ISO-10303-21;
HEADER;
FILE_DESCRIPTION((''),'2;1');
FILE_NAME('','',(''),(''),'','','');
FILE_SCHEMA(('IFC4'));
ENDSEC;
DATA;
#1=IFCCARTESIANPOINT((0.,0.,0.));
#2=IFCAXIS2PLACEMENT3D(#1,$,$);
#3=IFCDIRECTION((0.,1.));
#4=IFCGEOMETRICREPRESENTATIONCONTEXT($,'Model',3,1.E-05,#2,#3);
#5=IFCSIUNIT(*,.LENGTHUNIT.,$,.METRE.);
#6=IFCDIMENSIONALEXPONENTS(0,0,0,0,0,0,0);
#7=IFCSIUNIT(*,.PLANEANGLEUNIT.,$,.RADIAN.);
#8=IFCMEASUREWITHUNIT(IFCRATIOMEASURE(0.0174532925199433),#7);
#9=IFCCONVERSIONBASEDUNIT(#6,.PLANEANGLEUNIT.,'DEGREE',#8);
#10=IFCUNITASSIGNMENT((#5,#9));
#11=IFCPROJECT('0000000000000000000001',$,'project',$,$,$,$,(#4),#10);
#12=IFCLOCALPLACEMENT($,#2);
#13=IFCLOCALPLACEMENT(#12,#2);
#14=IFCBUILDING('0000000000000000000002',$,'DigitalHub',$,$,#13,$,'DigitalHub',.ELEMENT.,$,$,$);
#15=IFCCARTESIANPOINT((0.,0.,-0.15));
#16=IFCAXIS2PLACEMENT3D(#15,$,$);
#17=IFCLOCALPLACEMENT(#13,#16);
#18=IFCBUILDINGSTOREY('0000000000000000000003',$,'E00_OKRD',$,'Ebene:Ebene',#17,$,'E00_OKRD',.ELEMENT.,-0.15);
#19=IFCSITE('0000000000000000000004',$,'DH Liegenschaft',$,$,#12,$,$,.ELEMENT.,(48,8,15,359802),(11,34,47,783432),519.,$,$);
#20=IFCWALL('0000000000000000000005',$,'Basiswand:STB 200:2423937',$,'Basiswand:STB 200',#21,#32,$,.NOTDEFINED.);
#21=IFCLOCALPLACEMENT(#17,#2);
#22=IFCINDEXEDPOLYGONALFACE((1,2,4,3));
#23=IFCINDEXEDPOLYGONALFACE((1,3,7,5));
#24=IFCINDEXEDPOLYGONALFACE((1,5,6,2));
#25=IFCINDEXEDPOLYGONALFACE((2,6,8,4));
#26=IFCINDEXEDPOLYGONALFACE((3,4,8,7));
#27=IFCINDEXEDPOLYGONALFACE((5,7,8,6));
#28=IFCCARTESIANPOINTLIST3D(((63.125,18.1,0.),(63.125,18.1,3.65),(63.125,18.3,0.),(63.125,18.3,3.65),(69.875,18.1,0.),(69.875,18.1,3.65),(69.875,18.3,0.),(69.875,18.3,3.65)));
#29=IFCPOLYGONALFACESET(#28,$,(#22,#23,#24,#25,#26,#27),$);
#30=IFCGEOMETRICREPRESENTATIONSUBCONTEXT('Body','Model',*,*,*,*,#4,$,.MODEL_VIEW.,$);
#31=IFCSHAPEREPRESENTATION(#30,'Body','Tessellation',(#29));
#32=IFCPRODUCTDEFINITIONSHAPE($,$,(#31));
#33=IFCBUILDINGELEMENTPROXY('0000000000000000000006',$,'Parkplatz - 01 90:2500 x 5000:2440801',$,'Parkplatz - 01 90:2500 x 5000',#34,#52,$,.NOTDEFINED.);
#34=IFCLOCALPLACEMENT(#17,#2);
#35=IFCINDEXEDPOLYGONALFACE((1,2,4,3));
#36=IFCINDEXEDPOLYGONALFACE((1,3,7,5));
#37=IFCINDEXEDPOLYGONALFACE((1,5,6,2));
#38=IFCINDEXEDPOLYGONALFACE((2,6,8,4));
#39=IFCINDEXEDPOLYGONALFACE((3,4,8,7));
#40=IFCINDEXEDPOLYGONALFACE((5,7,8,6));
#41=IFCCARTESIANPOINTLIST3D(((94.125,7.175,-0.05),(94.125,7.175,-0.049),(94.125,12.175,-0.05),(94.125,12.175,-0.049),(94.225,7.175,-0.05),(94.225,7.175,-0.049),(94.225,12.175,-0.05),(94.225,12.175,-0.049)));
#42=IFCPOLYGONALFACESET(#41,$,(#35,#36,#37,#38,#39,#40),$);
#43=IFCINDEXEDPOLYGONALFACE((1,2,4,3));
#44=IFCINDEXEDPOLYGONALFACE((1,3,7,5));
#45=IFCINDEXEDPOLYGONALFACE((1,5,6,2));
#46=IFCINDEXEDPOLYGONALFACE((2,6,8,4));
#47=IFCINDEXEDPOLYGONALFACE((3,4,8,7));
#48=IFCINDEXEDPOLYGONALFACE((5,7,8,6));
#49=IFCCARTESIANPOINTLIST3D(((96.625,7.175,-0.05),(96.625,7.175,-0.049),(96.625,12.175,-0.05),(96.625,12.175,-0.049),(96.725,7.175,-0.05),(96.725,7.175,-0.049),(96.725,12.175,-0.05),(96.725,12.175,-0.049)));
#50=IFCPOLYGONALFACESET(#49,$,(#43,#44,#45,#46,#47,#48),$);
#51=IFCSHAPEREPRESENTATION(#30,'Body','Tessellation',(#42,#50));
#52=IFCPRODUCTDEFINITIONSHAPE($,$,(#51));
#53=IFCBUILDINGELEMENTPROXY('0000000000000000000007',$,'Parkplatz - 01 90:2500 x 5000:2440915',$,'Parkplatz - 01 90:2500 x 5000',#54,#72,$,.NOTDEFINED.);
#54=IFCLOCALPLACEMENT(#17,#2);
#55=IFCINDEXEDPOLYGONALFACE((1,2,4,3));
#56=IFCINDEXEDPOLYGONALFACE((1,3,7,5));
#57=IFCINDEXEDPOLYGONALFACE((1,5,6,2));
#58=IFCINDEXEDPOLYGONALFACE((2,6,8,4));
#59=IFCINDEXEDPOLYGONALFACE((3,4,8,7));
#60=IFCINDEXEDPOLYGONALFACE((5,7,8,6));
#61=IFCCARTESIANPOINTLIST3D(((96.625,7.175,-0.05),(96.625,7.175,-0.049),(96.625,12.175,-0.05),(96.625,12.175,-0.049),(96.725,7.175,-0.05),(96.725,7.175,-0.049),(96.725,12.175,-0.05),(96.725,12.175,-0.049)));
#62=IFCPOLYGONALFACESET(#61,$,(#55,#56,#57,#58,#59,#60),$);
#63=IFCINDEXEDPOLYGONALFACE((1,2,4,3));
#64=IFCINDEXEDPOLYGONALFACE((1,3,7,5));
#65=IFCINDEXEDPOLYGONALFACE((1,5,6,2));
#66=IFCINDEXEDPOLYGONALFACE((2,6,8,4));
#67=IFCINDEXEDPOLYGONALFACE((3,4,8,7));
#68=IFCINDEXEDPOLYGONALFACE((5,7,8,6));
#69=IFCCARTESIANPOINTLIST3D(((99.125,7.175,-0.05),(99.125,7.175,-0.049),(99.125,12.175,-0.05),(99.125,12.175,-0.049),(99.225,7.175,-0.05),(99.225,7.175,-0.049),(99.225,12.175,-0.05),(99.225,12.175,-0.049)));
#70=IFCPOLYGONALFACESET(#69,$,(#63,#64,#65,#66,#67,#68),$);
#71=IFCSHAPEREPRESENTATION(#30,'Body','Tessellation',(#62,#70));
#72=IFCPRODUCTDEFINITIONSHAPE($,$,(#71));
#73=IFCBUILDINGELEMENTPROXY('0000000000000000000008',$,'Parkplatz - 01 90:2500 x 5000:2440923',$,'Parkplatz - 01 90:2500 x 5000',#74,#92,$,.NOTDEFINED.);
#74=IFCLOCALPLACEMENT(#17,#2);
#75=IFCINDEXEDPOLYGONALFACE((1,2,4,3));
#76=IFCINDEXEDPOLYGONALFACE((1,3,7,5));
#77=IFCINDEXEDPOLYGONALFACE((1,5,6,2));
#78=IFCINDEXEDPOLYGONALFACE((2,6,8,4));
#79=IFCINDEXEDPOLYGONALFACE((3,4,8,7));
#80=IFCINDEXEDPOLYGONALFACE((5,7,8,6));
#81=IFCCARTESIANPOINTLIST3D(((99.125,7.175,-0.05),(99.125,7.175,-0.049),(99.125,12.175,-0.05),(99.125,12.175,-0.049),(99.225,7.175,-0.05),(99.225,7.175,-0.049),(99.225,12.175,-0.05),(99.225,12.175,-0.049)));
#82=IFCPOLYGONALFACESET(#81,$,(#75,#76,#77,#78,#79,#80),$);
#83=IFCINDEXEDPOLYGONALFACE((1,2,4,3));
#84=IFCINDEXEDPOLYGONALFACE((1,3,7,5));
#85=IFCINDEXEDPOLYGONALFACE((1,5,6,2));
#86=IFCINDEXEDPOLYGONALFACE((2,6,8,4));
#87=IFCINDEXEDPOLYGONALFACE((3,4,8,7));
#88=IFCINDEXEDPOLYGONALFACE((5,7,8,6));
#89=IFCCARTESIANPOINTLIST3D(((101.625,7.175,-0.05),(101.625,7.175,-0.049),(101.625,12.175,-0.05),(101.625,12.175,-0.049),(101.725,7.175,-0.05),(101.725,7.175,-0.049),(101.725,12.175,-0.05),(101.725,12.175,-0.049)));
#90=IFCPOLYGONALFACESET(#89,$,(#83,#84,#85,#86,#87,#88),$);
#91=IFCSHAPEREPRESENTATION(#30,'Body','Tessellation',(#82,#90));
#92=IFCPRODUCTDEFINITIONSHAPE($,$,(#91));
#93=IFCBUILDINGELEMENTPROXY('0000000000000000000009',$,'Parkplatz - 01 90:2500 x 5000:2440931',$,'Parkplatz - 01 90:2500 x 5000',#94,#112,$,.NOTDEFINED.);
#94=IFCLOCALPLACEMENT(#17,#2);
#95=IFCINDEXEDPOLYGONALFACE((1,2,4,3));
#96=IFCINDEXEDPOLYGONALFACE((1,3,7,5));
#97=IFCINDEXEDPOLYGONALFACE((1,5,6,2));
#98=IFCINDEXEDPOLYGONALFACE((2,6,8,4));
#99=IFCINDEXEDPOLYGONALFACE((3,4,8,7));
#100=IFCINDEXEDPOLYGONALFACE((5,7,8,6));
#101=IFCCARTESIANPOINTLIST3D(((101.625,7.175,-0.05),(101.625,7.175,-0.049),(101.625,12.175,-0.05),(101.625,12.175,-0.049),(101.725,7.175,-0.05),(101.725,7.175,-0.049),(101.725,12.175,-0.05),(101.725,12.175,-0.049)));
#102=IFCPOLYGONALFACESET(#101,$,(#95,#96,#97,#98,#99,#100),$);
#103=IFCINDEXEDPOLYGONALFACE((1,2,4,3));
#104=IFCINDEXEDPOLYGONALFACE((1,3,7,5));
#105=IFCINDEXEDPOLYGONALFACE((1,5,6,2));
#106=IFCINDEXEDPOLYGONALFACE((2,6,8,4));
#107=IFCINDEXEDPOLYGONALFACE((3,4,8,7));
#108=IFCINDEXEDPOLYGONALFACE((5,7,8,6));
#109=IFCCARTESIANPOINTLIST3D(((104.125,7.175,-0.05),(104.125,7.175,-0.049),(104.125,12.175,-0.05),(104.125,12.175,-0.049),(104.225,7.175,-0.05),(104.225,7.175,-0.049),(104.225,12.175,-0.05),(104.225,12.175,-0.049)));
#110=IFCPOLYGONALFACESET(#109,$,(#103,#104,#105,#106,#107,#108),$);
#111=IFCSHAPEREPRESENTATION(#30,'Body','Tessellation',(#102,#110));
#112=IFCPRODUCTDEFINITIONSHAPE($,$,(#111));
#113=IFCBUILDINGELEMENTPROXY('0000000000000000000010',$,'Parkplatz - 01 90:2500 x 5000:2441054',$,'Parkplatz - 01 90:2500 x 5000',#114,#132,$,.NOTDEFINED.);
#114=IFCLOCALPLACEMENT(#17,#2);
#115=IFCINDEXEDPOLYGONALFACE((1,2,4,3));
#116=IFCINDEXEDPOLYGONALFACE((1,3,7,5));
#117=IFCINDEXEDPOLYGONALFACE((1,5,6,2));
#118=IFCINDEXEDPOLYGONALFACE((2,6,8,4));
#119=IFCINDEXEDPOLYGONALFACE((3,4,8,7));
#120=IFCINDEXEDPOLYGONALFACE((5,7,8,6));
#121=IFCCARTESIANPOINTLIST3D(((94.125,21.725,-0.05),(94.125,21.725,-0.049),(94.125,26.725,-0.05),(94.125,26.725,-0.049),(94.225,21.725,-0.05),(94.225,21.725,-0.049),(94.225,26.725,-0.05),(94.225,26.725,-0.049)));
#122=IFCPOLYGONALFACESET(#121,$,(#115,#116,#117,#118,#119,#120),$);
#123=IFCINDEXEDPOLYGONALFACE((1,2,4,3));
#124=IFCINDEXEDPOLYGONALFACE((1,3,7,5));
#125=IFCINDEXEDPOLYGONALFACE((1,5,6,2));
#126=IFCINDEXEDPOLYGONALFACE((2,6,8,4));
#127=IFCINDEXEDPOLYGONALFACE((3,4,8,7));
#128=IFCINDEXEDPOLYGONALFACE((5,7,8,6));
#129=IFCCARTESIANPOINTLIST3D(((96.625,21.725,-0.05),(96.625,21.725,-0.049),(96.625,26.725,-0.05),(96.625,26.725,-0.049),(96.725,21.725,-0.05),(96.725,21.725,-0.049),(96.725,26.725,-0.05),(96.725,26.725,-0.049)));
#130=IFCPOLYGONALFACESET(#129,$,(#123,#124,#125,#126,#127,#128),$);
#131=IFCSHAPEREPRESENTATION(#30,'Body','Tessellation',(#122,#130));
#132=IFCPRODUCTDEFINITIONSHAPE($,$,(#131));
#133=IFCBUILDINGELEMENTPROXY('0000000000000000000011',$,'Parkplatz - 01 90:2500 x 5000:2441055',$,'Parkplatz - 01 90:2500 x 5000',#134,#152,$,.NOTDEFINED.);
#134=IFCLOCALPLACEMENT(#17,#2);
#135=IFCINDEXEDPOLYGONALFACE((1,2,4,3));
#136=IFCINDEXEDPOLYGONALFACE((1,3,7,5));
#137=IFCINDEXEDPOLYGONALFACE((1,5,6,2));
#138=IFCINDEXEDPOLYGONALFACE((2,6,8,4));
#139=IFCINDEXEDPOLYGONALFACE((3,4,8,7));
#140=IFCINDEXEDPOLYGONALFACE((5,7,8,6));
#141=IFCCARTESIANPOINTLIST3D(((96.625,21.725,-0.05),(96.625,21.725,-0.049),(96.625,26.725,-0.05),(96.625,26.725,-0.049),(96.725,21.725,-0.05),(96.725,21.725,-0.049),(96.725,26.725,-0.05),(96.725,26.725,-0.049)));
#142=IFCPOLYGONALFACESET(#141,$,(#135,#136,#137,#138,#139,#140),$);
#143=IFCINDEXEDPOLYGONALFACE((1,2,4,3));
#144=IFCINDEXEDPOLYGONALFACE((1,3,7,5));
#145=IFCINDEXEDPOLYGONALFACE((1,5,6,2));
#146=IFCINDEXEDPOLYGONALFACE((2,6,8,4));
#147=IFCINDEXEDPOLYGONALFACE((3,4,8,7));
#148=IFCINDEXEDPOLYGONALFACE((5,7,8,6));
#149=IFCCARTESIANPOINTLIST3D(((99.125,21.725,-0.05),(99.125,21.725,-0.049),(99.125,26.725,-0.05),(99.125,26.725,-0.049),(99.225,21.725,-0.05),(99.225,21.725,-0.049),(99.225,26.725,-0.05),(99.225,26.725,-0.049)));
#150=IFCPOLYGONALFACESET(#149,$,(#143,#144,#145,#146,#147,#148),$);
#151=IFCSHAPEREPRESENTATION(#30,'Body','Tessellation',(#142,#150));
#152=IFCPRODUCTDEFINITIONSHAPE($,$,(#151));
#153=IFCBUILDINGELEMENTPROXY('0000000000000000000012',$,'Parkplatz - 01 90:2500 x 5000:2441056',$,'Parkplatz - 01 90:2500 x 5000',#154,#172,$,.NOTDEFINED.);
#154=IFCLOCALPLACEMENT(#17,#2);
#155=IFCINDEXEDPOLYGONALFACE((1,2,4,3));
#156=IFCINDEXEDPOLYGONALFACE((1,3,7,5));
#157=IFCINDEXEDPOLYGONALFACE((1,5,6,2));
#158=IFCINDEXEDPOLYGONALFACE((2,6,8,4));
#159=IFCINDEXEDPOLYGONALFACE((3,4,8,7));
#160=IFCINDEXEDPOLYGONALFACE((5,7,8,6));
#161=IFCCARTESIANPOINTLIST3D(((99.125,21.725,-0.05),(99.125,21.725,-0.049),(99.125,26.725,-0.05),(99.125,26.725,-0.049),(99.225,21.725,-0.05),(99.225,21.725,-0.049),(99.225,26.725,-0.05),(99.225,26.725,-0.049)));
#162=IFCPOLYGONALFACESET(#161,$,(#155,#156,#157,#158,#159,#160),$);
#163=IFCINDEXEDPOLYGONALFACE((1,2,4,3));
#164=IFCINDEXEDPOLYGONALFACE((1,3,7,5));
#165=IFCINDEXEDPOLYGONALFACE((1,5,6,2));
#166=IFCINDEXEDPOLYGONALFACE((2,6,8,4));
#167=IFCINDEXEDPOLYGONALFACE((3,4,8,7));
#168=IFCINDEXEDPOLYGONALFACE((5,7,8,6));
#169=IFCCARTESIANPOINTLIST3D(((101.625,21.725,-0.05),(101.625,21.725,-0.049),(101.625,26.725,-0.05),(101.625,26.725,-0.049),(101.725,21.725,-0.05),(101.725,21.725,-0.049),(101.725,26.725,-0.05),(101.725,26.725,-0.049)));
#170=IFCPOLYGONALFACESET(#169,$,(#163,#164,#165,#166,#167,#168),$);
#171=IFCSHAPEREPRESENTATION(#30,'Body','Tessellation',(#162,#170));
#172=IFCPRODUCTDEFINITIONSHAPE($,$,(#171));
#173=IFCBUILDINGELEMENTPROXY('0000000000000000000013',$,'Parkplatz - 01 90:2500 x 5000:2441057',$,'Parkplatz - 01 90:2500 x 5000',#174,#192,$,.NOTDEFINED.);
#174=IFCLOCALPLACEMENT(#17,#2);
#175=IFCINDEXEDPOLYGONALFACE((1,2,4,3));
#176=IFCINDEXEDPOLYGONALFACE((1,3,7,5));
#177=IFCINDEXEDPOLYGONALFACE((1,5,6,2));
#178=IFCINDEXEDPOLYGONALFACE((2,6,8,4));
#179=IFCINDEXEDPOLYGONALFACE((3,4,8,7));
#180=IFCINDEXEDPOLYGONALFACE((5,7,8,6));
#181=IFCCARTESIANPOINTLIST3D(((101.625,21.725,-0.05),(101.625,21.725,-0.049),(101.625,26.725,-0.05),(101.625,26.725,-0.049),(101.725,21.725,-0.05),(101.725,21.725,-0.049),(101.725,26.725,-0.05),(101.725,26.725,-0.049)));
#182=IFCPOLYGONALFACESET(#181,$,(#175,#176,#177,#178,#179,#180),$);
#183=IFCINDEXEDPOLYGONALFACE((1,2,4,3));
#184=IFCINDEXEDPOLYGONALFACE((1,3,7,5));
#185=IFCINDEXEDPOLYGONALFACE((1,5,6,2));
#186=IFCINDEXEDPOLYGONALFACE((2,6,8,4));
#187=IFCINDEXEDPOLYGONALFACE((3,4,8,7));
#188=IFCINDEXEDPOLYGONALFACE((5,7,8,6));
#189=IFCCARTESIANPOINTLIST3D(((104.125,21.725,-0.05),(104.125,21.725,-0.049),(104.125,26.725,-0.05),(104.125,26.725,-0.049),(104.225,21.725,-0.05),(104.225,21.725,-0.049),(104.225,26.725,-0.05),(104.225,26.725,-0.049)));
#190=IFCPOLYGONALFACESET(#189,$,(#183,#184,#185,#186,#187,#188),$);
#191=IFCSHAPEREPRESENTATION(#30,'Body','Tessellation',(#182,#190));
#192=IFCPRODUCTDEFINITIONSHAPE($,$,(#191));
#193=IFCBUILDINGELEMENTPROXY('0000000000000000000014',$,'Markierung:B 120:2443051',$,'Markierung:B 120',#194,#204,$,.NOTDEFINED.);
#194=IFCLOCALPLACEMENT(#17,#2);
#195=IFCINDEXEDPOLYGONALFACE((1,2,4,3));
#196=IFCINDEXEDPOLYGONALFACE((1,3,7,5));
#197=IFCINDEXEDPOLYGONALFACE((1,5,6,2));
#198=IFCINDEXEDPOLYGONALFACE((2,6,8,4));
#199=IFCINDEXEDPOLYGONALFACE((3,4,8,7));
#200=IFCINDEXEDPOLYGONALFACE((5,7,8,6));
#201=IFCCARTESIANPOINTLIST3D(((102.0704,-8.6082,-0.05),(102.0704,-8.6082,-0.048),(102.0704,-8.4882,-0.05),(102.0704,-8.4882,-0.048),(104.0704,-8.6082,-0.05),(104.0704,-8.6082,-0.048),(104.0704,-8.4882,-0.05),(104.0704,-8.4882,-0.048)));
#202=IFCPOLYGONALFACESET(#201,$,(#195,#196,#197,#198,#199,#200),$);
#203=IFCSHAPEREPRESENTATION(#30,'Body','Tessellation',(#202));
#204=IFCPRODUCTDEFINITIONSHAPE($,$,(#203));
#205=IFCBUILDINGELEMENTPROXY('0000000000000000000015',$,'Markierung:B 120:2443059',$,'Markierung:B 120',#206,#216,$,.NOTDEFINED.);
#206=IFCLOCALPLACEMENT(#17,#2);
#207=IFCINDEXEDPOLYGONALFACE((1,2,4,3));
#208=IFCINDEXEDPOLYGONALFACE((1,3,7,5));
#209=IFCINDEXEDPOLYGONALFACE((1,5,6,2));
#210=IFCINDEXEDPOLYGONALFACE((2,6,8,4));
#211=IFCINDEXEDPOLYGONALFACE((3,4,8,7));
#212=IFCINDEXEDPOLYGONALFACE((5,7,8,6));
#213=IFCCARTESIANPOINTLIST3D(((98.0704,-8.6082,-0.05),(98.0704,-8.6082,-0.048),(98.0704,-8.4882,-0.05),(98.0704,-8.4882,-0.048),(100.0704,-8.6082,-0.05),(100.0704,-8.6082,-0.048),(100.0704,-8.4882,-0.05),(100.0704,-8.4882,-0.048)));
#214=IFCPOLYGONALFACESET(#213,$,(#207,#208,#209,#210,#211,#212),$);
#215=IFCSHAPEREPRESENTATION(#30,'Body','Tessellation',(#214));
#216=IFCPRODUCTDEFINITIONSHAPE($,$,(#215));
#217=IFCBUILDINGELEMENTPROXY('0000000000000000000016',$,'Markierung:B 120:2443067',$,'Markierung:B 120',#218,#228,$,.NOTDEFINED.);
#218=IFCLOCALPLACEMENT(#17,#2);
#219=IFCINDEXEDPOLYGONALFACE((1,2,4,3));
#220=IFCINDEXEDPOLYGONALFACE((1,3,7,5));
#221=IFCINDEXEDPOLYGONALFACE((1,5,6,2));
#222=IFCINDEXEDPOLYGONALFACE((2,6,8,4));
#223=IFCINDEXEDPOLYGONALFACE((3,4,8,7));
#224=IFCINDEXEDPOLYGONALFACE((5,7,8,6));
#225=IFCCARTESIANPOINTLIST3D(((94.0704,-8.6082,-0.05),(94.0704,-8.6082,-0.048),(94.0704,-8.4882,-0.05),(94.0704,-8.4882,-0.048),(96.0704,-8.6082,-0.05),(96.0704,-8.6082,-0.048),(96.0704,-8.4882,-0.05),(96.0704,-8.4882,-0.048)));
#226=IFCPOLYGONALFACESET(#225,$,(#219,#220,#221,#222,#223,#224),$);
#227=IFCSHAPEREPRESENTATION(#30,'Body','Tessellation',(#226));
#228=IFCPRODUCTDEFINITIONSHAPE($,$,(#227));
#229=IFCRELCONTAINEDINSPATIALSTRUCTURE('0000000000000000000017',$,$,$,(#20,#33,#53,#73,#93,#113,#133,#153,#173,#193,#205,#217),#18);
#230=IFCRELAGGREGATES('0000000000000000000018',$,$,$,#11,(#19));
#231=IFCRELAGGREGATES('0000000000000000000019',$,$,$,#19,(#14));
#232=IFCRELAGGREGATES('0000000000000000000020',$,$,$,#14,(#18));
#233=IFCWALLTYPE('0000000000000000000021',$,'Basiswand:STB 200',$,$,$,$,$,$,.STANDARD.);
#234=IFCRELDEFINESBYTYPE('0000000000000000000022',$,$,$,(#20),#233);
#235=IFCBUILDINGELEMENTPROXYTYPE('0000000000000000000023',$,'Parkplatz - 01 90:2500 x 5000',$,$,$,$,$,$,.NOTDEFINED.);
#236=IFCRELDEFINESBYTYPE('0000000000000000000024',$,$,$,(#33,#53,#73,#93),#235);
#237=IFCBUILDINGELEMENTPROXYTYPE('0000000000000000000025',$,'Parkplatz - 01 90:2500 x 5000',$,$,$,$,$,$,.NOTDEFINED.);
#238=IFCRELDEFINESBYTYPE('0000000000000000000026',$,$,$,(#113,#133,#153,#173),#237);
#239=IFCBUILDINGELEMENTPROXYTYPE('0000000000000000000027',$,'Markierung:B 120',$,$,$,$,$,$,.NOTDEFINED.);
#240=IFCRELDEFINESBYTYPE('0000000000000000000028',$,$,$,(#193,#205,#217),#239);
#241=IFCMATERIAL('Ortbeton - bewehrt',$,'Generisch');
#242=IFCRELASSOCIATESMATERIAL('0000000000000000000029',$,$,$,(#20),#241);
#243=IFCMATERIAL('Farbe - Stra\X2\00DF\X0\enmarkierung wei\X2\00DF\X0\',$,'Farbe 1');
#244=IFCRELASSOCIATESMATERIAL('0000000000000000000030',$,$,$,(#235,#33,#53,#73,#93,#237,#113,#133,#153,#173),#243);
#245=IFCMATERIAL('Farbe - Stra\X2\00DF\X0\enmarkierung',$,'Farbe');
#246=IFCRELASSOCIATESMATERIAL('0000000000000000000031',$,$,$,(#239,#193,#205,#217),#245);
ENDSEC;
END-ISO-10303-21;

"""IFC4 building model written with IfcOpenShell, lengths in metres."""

from ifc_helpers import new_model, entity, si_unit, converted_unit, direction, frame, origin, place, context, subcontext, project, spatial, indexed_curve, outline, extrude, source, transform, mapped, material, type_object, type_shapes, element, save


model = new_model("IFC4")

# Units and contexts
model_context = context("Model", 3, precision=1e-05, world=origin(), true_north=direction((0.0, 1.0)))
body_context = subcontext(model_context, "Body", "Model", "MODEL_VIEW")
ifc_project = project(units=[si_unit("LENGTHUNIT", "METRE"), converted_unit("PLANEANGLEUNIT", "DEGREE", entity("IfcRatioMeasure", 0.0174532925199433), si_unit("PLANEANGLEUNIT", "RADIAN"), dimensions=[0, 0, 0, 0, 0, 0, 0])], contexts=[model_context])

# Site, building, storey
site_placement = place(None, frame((0.0, 0.0, 0.0)))
site = spatial("IfcSite", under=ifc_project, at=site_placement, Name="DH Liegenschaft", CompositionType="ELEMENT", RefLatitude=(48, 8, 15, 359802), RefLongitude=(11, 34, 47, 783432), RefElevation=519.0)
building_placement = place(site_placement, origin())
building = spatial("IfcBuilding", under=site, at=building_placement, Name="DigitalHub", LongName="DigitalHub", CompositionType="ELEMENT")
storey_placement = place(building_placement, frame((0.0, 0.0, -0.15)))
storey = spatial("IfcBuildingStorey", under=building, at=storey_placement, Name="E00_OKRD", ObjectType="Ebene:Ebene", LongName="E00_OKRD", CompositionType="ELEMENT", Elevation=-0.15)

# Wall
ifc_material_1 = material(Name="Ortbeton - bewehrt", Category="Generisch")
wall_type = type_object("IfcWallType", Name="Basiswand:STB 200", PredefinedType="STANDARD")
wall_placement = place(storey_placement, frame((69.875, 18.2, 0.0), z_axis=(0.0, 0.0, 1.0), x_axis=(-1.0, 0.0, 0.0)))
element("IfcWall", 1, at=wall_placement, inside=storey, type_object=wall_type, material=ifc_material_1, Name="Basiswand:STB 200:2423937", ObjectType="Basiswand:STB 200", PredefinedType="NOTDEFINED", context=body_context, shape_type="SweptSolid", body=[
    extrude(outline(indexed_curve([(6.75, 0.1), (0.0, 0.1), (0.0, -0.1), (6.75, -0.1), (6.75, 0.1)], self_intersect=False)), origin(), (0.0, 0.0, 1.0), 3.65),
])

# Building element proxies
ifc_material_2 = material(Name="Farbe - Straßenmarkierung weiß", Category="Farbe 1")
building_element_proxy_type_1 = type_object("IfcBuildingElementProxyType", Name="Parkplatz - 01 90:2500 x 5000", PredefinedType="NOTDEFINED", material=ifc_material_2)
shared_shape_1 = source(origin(), body_context, "Body", "SweptSolid", [
    extrude(outline(indexed_curve([(-2.5, -0.05), (2.5, -0.05), (2.5, 0.05), (-2.5, 0.05), (-2.5, -0.05)], self_intersect=False)), frame((2.5456, -2.5, 0.0), z_axis=(0.0, 0.0, 1.0), x_axis=(0.0, -1.0, 0.0)), (0.0, 0.0, 1.0), 0.001),
    extrude(outline(indexed_curve([(-0.05, -2.5), (0.05, -2.5), (0.05, 2.5), (-0.05, 2.5), (-0.05, -2.5)], self_intersect=False)), frame((0.0456, -2.5, 0.0), z_axis=(0.0, 0.0, 1.0), x_axis=(-1.0, 0.0, 0.0)), (0.0, 0.0, 1.0), 0.001),
])
type_shapes(building_element_proxy_type_1, [shared_shape_1])
for number, where, z_axis, x_axis, name in (
    (2, (96.7206, 7.175, -0.05), (0.0, 0.0, 1.0), (-1.0, 0.0, 0.0), "Parkplatz - 01 90:2500 x 5000:2440801"),
    (3, (99.2206, 7.175, -0.05), (0.0, 0.0, 1.0), (-1.0, 0.0, 0.0), "Parkplatz - 01 90:2500 x 5000:2440915"),
    (4, (101.7206, 7.175, -0.05), (0.0, 0.0, 1.0), (-1.0, 0.0, 0.0), "Parkplatz - 01 90:2500 x 5000:2440923"),
    (5, (104.2206, 7.175, -0.05), (0.0, 0.0, 1.0), (-1.0, 0.0, 0.0), "Parkplatz - 01 90:2500 x 5000:2440931"),
):
    element("IfcBuildingElementProxy", number, at=place(storey_placement, frame(where, z_axis=z_axis, x_axis=x_axis)), inside=storey, type_object=building_element_proxy_type_1, material=ifc_material_2, Name=name, ObjectType="Parkplatz - 01 90:2500 x 5000", PredefinedType="NOTDEFINED", context=body_context, shape_type="MappedRepresentation", body=[
        mapped(shared_shape_1, transform((0.0, 0.0, 0.0), scale=1.0)),
    ])
building_element_proxy_type_2 = type_object("IfcBuildingElementProxyType", Name="Parkplatz - 01 90:2500 x 5000", PredefinedType="NOTDEFINED", material=ifc_material_2)
shared_shape_2 = source(origin(), body_context, "Body", "SweptSolid", [
    extrude(outline(indexed_curve([(-0.05, -2.5), (0.05, -2.5), (0.05, 2.5), (-0.05, 2.5), (-0.05, -2.5)], self_intersect=False)), frame((2.5456, 2.5, 0.0)), (0.0, 0.0, 1.0), 0.001),
    extrude(outline(indexed_curve([(-2.5, -0.05), (2.5, -0.05), (2.5, 0.05), (-2.5, 0.05), (-2.5, -0.05)], self_intersect=False)), frame((0.0456, 2.5, 0.0), z_axis=(0.0, 0.0, 1.0), x_axis=(0.0, 1.0, 0.0)), (0.0, 0.0, 1.0), 0.001),
])
type_shapes(building_element_proxy_type_2, [shared_shape_2])
for number, where, z_axis, x_axis, name in (
    (6, (96.7206, 26.725, -0.05), (0.0, 0.0, 1.0), (-1.0, 0.0, 0.0), "Parkplatz - 01 90:2500 x 5000:2441054"),
    (7, (99.2206, 26.725, -0.05), (0.0, 0.0, 1.0), (-1.0, 0.0, 0.0), "Parkplatz - 01 90:2500 x 5000:2441055"),
    (8, (101.7206, 26.725, -0.05), (0.0, 0.0, 1.0), (-1.0, 0.0, 0.0), "Parkplatz - 01 90:2500 x 5000:2441056"),
    (9, (104.2206, 26.725, -0.05), (0.0, 0.0, 1.0), (-1.0, 0.0, 0.0), "Parkplatz - 01 90:2500 x 5000:2441057"),
):
    element("IfcBuildingElementProxy", number, at=place(storey_placement, frame(where, z_axis=z_axis, x_axis=x_axis)), inside=storey, type_object=building_element_proxy_type_2, material=ifc_material_2, Name=name, ObjectType="Parkplatz - 01 90:2500 x 5000", PredefinedType="NOTDEFINED", context=body_context, shape_type="MappedRepresentation", body=[
        mapped(shared_shape_2, transform((0.0, 0.0, 0.0), scale=1.0)),
    ])
ifc_material_3 = material(Name="Farbe - Straßenmarkierung", Category="Farbe")
building_element_proxy_type_3 = type_object("IfcBuildingElementProxyType", Name="Markierung:B 120", PredefinedType="NOTDEFINED", material=ifc_material_3)
shared_shape_3 = source(origin(), body_context, "Body", "SweptSolid", [
    extrude(outline(indexed_curve([(-0.06, -1.0), (0.06, -1.0), (0.06, 1.0), (-0.06, 1.0), (-0.06, -1.0)], self_intersect=False)), frame((0.06, 1.0, 0.0), z_axis=(0.0, 0.0, 1.0), x_axis=(-1.0, 0.0, 0.0)), (0.0, 0.0, 1.0), 0.002),
])
type_shapes(building_element_proxy_type_3, [shared_shape_3])
for number, where, z_axis, x_axis, name in (
    (10, (104.0704, -8.6082, -0.05), (0.0, 0.0, 1.0), (0.0, 1.0, 0.0), "Markierung:B 120:2443051"),
    (11, (100.0704, -8.6082, -0.05), (0.0, 0.0, 1.0), (0.0, 1.0, 0.0), "Markierung:B 120:2443059"),
    (12, (96.0704, -8.6082, -0.05), (0.0, 0.0, 1.0), (0.0, 1.0, 0.0), "Markierung:B 120:2443067"),
):
    element("IfcBuildingElementProxy", number, at=place(storey_placement, frame(where, z_axis=z_axis, x_axis=x_axis)), inside=storey, type_object=building_element_proxy_type_3, material=ifc_material_3, Name=name, ObjectType="Markierung:B 120", PredefinedType="NOTDEFINED", context=body_context, shape_type="MappedRepresentation", body=[
        mapped(shared_shape_3, transform((0.0, 0.0, 0.0), scale=1.0)),
    ])

save(model, "model.ifc")
